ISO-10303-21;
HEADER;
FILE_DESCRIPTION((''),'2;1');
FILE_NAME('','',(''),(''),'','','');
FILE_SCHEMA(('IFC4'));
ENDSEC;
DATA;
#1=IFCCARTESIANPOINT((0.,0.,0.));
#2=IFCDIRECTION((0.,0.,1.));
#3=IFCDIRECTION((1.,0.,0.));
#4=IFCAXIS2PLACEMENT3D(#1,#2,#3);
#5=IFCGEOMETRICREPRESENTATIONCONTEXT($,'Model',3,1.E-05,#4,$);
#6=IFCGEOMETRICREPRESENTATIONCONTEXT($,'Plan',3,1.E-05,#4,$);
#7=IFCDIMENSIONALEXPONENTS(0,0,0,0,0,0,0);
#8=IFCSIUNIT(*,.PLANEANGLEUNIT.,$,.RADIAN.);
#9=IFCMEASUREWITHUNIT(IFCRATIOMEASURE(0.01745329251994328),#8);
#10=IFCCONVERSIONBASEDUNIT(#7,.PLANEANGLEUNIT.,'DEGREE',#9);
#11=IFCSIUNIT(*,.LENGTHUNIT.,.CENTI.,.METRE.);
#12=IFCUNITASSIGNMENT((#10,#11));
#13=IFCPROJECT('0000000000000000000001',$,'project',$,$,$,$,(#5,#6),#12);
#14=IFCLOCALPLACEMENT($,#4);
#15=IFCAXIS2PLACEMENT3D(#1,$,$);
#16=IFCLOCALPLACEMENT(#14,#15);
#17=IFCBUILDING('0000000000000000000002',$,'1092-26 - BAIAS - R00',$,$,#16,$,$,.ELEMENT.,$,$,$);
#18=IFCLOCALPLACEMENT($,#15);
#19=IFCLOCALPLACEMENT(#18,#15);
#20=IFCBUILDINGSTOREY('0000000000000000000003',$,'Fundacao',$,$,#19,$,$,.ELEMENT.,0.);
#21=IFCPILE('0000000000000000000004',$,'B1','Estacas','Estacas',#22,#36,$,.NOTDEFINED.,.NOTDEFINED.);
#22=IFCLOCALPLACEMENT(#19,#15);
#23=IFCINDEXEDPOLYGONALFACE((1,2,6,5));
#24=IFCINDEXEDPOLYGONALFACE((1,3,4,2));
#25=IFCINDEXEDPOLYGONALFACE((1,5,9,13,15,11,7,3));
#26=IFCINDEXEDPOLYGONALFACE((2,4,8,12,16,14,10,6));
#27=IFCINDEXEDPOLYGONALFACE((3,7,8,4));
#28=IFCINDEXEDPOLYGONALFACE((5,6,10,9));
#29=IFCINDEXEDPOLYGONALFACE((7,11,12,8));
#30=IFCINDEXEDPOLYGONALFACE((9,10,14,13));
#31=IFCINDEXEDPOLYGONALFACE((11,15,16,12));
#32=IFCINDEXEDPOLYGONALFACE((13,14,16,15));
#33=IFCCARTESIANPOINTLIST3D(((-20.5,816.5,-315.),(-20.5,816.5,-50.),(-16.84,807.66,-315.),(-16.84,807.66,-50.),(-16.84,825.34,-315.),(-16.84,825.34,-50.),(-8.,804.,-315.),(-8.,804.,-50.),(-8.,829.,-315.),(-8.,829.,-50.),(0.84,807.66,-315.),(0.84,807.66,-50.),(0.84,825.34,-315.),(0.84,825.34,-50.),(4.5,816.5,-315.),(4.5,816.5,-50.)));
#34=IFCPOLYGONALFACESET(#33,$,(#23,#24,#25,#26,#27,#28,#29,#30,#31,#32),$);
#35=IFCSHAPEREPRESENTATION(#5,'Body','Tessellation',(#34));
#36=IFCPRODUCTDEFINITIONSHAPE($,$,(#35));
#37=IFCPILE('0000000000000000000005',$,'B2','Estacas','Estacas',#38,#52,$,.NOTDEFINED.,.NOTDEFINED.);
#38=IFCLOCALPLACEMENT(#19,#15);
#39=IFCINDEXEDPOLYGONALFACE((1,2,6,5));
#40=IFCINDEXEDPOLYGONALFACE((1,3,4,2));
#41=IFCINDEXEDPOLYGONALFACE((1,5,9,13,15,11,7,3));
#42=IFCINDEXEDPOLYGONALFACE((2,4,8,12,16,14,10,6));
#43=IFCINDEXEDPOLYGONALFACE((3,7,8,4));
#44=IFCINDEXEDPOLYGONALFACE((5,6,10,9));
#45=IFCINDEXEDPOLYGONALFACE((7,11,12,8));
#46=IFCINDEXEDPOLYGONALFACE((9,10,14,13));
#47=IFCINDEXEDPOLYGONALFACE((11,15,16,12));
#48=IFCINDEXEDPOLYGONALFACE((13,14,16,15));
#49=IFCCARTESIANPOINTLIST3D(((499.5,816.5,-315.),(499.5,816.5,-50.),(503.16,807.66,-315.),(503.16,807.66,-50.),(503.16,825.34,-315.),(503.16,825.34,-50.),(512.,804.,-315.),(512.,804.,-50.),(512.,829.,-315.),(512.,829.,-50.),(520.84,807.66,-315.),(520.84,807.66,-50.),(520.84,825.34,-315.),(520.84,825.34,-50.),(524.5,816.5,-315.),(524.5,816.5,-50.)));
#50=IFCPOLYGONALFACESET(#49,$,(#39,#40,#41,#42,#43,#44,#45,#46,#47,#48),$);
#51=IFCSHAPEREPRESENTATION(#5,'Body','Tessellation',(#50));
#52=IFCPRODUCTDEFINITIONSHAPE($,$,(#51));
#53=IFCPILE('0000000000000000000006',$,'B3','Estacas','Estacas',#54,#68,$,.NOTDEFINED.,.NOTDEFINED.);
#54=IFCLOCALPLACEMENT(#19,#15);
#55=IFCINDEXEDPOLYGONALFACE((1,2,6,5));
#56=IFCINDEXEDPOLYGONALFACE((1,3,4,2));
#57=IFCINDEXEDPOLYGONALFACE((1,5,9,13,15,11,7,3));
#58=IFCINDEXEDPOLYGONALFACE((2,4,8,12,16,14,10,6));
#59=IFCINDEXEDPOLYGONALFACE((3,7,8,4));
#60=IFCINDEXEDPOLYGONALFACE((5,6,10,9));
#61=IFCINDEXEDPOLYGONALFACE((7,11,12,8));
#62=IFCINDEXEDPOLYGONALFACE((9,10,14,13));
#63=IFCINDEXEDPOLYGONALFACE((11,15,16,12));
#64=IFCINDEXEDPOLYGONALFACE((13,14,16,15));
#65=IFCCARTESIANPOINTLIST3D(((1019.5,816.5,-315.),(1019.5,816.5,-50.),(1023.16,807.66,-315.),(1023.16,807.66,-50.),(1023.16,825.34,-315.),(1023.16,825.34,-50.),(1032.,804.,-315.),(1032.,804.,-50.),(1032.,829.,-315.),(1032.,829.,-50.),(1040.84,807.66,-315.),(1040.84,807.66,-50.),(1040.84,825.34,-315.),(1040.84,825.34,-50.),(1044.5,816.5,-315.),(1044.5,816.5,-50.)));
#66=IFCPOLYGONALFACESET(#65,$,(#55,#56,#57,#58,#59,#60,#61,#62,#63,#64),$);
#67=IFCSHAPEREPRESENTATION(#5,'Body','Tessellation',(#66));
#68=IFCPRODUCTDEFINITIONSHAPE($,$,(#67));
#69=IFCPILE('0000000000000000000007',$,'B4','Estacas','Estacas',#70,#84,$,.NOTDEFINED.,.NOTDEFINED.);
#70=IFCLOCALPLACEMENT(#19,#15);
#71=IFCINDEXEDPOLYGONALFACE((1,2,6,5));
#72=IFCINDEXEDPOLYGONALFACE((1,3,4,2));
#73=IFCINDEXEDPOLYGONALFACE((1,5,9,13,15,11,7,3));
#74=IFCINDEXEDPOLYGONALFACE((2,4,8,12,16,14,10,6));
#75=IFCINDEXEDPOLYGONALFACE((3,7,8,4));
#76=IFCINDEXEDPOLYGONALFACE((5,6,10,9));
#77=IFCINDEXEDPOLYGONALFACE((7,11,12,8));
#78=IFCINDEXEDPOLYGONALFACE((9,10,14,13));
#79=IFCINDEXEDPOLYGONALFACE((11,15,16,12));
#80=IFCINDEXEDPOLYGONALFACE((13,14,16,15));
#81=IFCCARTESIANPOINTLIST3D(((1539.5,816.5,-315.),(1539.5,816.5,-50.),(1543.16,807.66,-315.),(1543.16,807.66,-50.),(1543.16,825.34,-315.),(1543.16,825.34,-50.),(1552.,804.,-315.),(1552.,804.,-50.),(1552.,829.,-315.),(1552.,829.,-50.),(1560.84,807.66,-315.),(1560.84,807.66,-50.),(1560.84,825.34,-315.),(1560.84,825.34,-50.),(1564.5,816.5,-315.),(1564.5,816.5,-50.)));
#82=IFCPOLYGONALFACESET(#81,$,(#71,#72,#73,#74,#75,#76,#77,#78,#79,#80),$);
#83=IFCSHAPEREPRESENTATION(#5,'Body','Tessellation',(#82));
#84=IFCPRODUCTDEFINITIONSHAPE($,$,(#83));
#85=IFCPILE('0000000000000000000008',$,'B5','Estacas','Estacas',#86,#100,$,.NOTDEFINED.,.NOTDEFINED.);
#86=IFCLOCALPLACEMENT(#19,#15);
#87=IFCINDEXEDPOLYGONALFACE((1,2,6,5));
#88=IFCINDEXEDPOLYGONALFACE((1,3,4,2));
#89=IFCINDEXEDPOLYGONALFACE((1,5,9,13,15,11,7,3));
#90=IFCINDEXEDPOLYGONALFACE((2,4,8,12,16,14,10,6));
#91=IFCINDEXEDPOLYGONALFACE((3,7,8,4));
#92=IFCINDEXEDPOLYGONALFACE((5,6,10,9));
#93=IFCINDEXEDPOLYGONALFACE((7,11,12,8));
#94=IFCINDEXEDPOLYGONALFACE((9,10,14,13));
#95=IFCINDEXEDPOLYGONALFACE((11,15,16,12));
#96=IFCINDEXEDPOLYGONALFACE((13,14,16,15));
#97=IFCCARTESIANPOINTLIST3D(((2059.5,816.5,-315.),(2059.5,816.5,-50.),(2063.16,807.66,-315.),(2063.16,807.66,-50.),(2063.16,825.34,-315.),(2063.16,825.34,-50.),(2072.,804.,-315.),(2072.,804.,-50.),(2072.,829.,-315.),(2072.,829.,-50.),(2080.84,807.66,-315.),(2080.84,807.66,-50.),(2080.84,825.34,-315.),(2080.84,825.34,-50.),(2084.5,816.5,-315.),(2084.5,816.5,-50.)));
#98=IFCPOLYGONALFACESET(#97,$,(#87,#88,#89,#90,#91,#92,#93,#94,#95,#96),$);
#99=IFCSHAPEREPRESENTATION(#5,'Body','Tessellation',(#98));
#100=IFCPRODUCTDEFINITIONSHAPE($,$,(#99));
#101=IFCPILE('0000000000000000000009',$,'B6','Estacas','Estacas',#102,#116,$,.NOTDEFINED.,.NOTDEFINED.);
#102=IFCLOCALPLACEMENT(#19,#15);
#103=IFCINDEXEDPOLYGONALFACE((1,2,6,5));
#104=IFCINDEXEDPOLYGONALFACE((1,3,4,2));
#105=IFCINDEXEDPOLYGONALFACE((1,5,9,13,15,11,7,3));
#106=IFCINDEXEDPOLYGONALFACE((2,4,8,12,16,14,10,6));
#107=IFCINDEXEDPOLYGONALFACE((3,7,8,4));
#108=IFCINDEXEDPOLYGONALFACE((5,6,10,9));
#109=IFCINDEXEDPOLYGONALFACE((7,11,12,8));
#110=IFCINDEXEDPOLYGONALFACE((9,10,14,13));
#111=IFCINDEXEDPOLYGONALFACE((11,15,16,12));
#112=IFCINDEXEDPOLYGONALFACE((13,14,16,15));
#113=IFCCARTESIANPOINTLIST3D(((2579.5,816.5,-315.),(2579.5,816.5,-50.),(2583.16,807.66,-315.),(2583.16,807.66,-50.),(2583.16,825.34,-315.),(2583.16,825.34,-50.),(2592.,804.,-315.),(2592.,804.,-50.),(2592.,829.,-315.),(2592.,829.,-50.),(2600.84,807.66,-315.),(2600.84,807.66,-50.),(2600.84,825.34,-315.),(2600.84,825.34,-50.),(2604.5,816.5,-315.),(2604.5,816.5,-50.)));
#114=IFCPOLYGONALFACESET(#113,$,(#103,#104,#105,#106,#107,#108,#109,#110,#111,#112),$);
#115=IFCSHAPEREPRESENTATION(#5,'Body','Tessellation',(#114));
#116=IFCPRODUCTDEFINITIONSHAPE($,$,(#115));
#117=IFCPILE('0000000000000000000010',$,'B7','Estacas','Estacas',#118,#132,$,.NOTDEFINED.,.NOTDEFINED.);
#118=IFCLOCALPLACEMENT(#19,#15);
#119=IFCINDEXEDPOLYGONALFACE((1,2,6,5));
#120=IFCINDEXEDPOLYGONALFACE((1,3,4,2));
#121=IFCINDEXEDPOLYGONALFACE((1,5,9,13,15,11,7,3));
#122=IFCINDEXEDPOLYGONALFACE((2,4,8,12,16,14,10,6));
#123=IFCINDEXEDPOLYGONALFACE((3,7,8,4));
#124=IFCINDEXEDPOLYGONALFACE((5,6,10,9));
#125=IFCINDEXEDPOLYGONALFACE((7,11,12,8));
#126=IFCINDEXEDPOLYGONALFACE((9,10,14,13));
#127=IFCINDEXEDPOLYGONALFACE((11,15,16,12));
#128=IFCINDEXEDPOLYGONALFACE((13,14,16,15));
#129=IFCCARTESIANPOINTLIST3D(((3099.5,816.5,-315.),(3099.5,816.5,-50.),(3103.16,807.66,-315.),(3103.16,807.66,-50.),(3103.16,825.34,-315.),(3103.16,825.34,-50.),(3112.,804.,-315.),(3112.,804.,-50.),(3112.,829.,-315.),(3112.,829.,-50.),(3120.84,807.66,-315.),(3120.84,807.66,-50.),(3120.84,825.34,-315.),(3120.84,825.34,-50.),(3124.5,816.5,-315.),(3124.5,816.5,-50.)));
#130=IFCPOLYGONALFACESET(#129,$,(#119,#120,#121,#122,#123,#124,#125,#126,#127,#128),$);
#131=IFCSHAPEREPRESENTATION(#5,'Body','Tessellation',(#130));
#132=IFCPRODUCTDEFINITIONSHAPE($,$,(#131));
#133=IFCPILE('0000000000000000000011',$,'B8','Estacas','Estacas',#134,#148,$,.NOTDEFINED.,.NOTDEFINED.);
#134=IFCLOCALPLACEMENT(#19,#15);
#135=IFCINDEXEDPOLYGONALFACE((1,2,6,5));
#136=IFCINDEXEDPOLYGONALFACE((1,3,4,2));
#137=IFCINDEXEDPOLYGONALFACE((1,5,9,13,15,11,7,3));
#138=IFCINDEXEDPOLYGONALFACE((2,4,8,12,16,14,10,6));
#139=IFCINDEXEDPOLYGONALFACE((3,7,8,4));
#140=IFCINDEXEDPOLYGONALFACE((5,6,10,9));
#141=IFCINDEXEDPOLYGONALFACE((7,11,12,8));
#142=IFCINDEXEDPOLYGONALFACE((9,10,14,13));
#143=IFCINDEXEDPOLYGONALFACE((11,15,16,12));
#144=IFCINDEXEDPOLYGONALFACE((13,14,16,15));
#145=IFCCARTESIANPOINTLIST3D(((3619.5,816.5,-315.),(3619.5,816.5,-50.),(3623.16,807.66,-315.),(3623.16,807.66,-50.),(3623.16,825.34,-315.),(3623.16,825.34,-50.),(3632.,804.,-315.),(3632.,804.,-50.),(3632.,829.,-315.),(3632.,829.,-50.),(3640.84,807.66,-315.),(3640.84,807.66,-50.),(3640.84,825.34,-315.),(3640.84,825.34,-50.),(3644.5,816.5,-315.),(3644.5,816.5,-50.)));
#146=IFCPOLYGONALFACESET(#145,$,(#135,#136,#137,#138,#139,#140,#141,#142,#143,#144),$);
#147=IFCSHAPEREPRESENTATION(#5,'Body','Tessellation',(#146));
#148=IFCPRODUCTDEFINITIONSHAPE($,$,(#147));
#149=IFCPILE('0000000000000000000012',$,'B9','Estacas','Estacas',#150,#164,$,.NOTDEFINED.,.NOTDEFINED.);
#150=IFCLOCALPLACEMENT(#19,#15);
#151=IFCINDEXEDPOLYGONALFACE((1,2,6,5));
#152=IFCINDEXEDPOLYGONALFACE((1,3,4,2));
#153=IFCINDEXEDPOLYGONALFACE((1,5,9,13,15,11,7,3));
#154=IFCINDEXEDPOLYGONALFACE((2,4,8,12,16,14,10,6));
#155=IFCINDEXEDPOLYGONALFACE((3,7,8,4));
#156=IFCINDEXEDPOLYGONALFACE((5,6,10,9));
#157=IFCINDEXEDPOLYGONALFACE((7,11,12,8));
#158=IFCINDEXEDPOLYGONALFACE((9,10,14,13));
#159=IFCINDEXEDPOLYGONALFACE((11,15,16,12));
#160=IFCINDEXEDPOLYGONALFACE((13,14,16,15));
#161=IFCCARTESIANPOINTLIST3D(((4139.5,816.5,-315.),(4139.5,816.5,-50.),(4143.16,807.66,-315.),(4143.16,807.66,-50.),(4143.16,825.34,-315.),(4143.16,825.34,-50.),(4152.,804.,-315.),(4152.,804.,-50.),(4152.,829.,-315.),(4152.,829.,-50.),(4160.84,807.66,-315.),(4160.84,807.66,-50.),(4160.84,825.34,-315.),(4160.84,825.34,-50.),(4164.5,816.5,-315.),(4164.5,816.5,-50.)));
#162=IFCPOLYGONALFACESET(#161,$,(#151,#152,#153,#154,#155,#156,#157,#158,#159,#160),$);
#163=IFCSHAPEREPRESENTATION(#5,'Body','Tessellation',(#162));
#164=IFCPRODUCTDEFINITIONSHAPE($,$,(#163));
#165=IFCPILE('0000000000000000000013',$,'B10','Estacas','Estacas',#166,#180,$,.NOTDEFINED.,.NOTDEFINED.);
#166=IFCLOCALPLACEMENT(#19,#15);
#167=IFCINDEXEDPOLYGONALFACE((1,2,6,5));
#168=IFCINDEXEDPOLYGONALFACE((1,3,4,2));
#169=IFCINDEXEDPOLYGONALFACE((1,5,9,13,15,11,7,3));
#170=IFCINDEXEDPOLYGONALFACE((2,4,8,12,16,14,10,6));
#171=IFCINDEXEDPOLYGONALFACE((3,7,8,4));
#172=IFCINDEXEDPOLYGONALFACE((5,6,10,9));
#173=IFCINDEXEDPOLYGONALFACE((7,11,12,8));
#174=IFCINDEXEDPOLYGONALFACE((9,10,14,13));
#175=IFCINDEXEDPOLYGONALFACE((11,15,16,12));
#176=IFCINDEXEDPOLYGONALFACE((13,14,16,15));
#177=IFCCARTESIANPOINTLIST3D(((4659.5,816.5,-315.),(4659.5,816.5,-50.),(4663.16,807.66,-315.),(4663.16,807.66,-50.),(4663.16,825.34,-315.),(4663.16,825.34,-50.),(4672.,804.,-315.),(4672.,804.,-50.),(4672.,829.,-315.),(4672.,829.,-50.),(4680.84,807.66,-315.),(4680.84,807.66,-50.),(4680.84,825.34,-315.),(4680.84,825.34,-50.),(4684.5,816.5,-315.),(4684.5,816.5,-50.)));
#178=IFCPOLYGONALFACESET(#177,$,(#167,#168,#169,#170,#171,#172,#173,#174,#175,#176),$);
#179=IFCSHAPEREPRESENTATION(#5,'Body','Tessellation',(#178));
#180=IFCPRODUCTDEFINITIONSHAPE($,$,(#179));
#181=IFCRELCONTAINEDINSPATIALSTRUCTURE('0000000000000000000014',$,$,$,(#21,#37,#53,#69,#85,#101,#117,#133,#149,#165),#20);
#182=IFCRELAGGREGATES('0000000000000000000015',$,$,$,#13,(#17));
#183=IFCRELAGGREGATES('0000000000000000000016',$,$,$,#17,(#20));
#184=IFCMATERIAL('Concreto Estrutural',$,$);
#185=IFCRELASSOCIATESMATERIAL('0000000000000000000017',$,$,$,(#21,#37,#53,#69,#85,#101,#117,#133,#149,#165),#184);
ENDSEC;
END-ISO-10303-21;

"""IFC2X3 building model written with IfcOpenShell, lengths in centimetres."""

from ifc_helpers import new_model, entity, si_unit, converted_unit, frame, origin, origin_with_axes, place, context, project, spatial, polyline, outline, extrude, material, element, save


model = new_model("IFC2X3")

# Units and contexts
model_context = context("Model", 3, precision=1e-05, world=origin_with_axes())
plan_context = context("Plan", 3, precision=1e-05, world=origin_with_axes())
ifc_project = project(units=[converted_unit("PLANEANGLEUNIT", "DEGREE", entity("IfcRatioMeasure", 0.01745329251994328), si_unit("PLANEANGLEUNIT", "RADIAN"), dimensions=[0, 0, 0, 0, 0, 0, 0]), si_unit("LENGTHUNIT", "METRE", prefix="CENTI")], contexts=[model_context, plan_context])

# Building, storey
placement_1 = place(None, origin_with_axes())
building_placement = place(placement_1, origin())
building = spatial("IfcBuilding", under=ifc_project, at=building_placement, Name="1092-26 - BAIAS - R00", CompositionType="ELEMENT")
placement_2 = place(None, origin())
storey_placement = place(placement_2, origin())
storey = spatial("IfcBuildingStorey", under=building, at=storey_placement, Name="Fundacao", CompositionType="ELEMENT", Elevation=0.0)

# Piles
ifc_material_1 = material(Name="Concreto Estrutural")
placement_3 = place(None, origin_with_axes())
placement_4 = place(placement_3, origin_with_axes())
placement_5 = place(placement_4, origin_with_axes())
pile_1_placement = place(placement_5, frame((-8.0, 816.5, -315.0), z_axis=(0.0, 0.0, 1.0), x_axis=(1.0, 0.0, 0.0)))
element("IfcPile", 1, at=pile_1_placement, inside=storey, material=ifc_material_1, Name="B1", Description="Estacas", ObjectType="Estacas", ConstructionType="NOTDEFINED", PredefinedType="NOTDEFINED", context=model_context, shape_type="SweptSolid", body=[
    extrude(outline(polyline([(8.84, -8.84, 0.0), (0.0, -12.5, 0.0), (-8.84, -8.84, 0.0), (-12.5, 0.0, 0.0), (-8.84, 8.84, 0.0), (0.0, 12.5, 0.0), (8.84, 8.84, 0.0), (12.5, 0.0, 0.0), (8.84, -8.84, 0.0)])), origin_with_axes(), (0.0, 0.0, 1.0), 265.0),
])
placement_6 = place(placement_4, origin_with_axes())
pile_2_placement = place(placement_6, frame((512.0, 816.5, -315.0), z_axis=(0.0, 0.0, 1.0), x_axis=(1.0, 0.0, 0.0)))
element("IfcPile", 2, at=pile_2_placement, inside=storey, material=ifc_material_1, Name="B2", Description="Estacas", ObjectType="Estacas", ConstructionType="NOTDEFINED", PredefinedType="NOTDEFINED", context=model_context, shape_type="SweptSolid", body=[
    extrude(outline(polyline([(8.84, -8.84, 0.0), (0.0, -12.5, 0.0), (-8.84, -8.84, 0.0), (-12.5, 0.0, 0.0), (-8.84, 8.84, 0.0), (0.0, 12.5, 0.0), (8.84, 8.84, 0.0), (12.5, 0.0, 0.0), (8.84, -8.84, 0.0)])), origin_with_axes(), (0.0, 0.0, 1.0), 265.0),
])
placement_7 = place(placement_4, origin_with_axes())
pile_3_placement = place(placement_7, frame((1032.0, 816.5, -315.0), z_axis=(0.0, 0.0, 1.0), x_axis=(1.0, 0.0, 0.0)))
element("IfcPile", 3, at=pile_3_placement, inside=storey, material=ifc_material_1, Name="B3", Description="Estacas", ObjectType="Estacas", ConstructionType="NOTDEFINED", PredefinedType="NOTDEFINED", context=model_context, shape_type="SweptSolid", body=[
    extrude(outline(polyline([(8.84, -8.84, 0.0), (0.0, -12.5, 0.0), (-8.84, -8.84, 0.0), (-12.5, 0.0, 0.0), (-8.84, 8.84, 0.0), (0.0, 12.5, 0.0), (8.84, 8.84, 0.0), (12.5, 0.0, 0.0), (8.84, -8.84, 0.0)])), origin_with_axes(), (0.0, 0.0, 1.0), 265.0),
])
placement_8 = place(placement_4, origin_with_axes())
pile_4_placement = place(placement_8, frame((1552.0, 816.5, -315.0), z_axis=(0.0, 0.0, 1.0), x_axis=(1.0, 0.0, 0.0)))
element("IfcPile", 4, at=pile_4_placement, inside=storey, material=ifc_material_1, Name="B4", Description="Estacas", ObjectType="Estacas", ConstructionType="NOTDEFINED", PredefinedType="NOTDEFINED", context=model_context, shape_type="SweptSolid", body=[
    extrude(outline(polyline([(8.84, -8.84, 0.0), (0.0, -12.5, 0.0), (-8.84, -8.84, 0.0), (-12.5, 0.0, 0.0), (-8.84, 8.84, 0.0), (0.0, 12.5, 0.0), (8.84, 8.84, 0.0), (12.5, 0.0, 0.0), (8.84, -8.84, 0.0)])), origin_with_axes(), (0.0, 0.0, 1.0), 265.0),
])
placement_9 = place(placement_4, origin_with_axes())
pile_5_placement = place(placement_9, frame((2072.0, 816.5, -315.0), z_axis=(0.0, 0.0, 1.0), x_axis=(1.0, 0.0, 0.0)))
element("IfcPile", 5, at=pile_5_placement, inside=storey, material=ifc_material_1, Name="B5", Description="Estacas", ObjectType="Estacas", ConstructionType="NOTDEFINED", PredefinedType="NOTDEFINED", context=model_context, shape_type="SweptSolid", body=[
    extrude(outline(polyline([(8.84, -8.84, 0.0), (0.0, -12.5, 0.0), (-8.84, -8.84, 0.0), (-12.5, 0.0, 0.0), (-8.84, 8.84, 0.0), (0.0, 12.5, 0.0), (8.84, 8.84, 0.0), (12.5, 0.0, 0.0), (8.84, -8.84, 0.0)])), origin_with_axes(), (0.0, 0.0, 1.0), 265.0),
])
placement_10 = place(placement_4, origin_with_axes())
pile_6_placement = place(placement_10, frame((2592.0, 816.5, -315.0), z_axis=(0.0, 0.0, 1.0), x_axis=(1.0, 0.0, 0.0)))
element("IfcPile", 6, at=pile_6_placement, inside=storey, material=ifc_material_1, Name="B6", Description="Estacas", ObjectType="Estacas", ConstructionType="NOTDEFINED", PredefinedType="NOTDEFINED", context=model_context, shape_type="SweptSolid", body=[
    extrude(outline(polyline([(8.84, -8.84, 0.0), (0.0, -12.5, 0.0), (-8.84, -8.84, 0.0), (-12.5, 0.0, 0.0), (-8.84, 8.84, 0.0), (0.0, 12.5, 0.0), (8.84, 8.84, 0.0), (12.5, 0.0, 0.0), (8.84, -8.84, 0.0)])), origin_with_axes(), (0.0, 0.0, 1.0), 265.0),
])
placement_11 = place(placement_4, origin_with_axes())
pile_7_placement = place(placement_11, frame((3112.0, 816.5, -315.0), z_axis=(0.0, 0.0, 1.0), x_axis=(1.0, 0.0, 0.0)))
element("IfcPile", 7, at=pile_7_placement, inside=storey, material=ifc_material_1, Name="B7", Description="Estacas", ObjectType="Estacas", ConstructionType="NOTDEFINED", PredefinedType="NOTDEFINED", context=model_context, shape_type="SweptSolid", body=[
    extrude(outline(polyline([(8.84, -8.84, 0.0), (0.0, -12.5, 0.0), (-8.84, -8.84, 0.0), (-12.5, 0.0, 0.0), (-8.84, 8.84, 0.0), (0.0, 12.5, 0.0), (8.84, 8.84, 0.0), (12.5, 0.0, 0.0), (8.84, -8.84, 0.0)])), origin_with_axes(), (0.0, 0.0, 1.0), 265.0),
])
placement_12 = place(placement_4, origin_with_axes())
pile_8_placement = place(placement_12, frame((3632.0, 816.5, -315.0), z_axis=(0.0, 0.0, 1.0), x_axis=(1.0, 0.0, 0.0)))
element("IfcPile", 8, at=pile_8_placement, inside=storey, material=ifc_material_1, Name="B8", Description="Estacas", ObjectType="Estacas", ConstructionType="NOTDEFINED", PredefinedType="NOTDEFINED", context=model_context, shape_type="SweptSolid", body=[
    extrude(outline(polyline([(8.84, -8.84, 0.0), (0.0, -12.5, 0.0), (-8.84, -8.84, 0.0), (-12.5, 0.0, 0.0), (-8.84, 8.84, 0.0), (0.0, 12.5, 0.0), (8.84, 8.84, 0.0), (12.5, 0.0, 0.0), (8.84, -8.84, 0.0)])), origin_with_axes(), (0.0, 0.0, 1.0), 265.0),
])
placement_13 = place(placement_4, origin_with_axes())
pile_9_placement = place(placement_13, frame((4152.0, 816.5, -315.0), z_axis=(0.0, 0.0, 1.0), x_axis=(1.0, 0.0, 0.0)))
element("IfcPile", 9, at=pile_9_placement, inside=storey, material=ifc_material_1, Name="B9", Description="Estacas", ObjectType="Estacas", ConstructionType="NOTDEFINED", PredefinedType="NOTDEFINED", context=model_context, shape_type="SweptSolid", body=[
    extrude(outline(polyline([(8.84, -8.84, 0.0), (0.0, -12.5, 0.0), (-8.84, -8.84, 0.0), (-12.5, 0.0, 0.0), (-8.84, 8.84, 0.0), (0.0, 12.5, 0.0), (8.84, 8.84, 0.0), (12.5, 0.0, 0.0), (8.84, -8.84, 0.0)])), origin_with_axes(), (0.0, 0.0, 1.0), 265.0),
])
placement_14 = place(placement_4, origin_with_axes())
pile_10_placement = place(placement_14, frame((4672.0, 816.5, -315.0), z_axis=(0.0, 0.0, 1.0), x_axis=(1.0, 0.0, 0.0)))
element("IfcPile", 10, at=pile_10_placement, inside=storey, material=ifc_material_1, Name="B10", Description="Estacas", ObjectType="Estacas", ConstructionType="NOTDEFINED", PredefinedType="NOTDEFINED", context=model_context, shape_type="SweptSolid", body=[
    extrude(outline(polyline([(8.84, -8.84, 0.0), (0.0, -12.5, 0.0), (-8.84, -8.84, 0.0), (-12.5, 0.0, 0.0), (-8.84, 8.84, 0.0), (0.0, 12.5, 0.0), (8.84, 8.84, 0.0), (12.5, 0.0, 0.0), (8.84, -8.84, 0.0)])), origin_with_axes(), (0.0, 0.0, 1.0), 265.0),
])

save(model, "model.ifc")
